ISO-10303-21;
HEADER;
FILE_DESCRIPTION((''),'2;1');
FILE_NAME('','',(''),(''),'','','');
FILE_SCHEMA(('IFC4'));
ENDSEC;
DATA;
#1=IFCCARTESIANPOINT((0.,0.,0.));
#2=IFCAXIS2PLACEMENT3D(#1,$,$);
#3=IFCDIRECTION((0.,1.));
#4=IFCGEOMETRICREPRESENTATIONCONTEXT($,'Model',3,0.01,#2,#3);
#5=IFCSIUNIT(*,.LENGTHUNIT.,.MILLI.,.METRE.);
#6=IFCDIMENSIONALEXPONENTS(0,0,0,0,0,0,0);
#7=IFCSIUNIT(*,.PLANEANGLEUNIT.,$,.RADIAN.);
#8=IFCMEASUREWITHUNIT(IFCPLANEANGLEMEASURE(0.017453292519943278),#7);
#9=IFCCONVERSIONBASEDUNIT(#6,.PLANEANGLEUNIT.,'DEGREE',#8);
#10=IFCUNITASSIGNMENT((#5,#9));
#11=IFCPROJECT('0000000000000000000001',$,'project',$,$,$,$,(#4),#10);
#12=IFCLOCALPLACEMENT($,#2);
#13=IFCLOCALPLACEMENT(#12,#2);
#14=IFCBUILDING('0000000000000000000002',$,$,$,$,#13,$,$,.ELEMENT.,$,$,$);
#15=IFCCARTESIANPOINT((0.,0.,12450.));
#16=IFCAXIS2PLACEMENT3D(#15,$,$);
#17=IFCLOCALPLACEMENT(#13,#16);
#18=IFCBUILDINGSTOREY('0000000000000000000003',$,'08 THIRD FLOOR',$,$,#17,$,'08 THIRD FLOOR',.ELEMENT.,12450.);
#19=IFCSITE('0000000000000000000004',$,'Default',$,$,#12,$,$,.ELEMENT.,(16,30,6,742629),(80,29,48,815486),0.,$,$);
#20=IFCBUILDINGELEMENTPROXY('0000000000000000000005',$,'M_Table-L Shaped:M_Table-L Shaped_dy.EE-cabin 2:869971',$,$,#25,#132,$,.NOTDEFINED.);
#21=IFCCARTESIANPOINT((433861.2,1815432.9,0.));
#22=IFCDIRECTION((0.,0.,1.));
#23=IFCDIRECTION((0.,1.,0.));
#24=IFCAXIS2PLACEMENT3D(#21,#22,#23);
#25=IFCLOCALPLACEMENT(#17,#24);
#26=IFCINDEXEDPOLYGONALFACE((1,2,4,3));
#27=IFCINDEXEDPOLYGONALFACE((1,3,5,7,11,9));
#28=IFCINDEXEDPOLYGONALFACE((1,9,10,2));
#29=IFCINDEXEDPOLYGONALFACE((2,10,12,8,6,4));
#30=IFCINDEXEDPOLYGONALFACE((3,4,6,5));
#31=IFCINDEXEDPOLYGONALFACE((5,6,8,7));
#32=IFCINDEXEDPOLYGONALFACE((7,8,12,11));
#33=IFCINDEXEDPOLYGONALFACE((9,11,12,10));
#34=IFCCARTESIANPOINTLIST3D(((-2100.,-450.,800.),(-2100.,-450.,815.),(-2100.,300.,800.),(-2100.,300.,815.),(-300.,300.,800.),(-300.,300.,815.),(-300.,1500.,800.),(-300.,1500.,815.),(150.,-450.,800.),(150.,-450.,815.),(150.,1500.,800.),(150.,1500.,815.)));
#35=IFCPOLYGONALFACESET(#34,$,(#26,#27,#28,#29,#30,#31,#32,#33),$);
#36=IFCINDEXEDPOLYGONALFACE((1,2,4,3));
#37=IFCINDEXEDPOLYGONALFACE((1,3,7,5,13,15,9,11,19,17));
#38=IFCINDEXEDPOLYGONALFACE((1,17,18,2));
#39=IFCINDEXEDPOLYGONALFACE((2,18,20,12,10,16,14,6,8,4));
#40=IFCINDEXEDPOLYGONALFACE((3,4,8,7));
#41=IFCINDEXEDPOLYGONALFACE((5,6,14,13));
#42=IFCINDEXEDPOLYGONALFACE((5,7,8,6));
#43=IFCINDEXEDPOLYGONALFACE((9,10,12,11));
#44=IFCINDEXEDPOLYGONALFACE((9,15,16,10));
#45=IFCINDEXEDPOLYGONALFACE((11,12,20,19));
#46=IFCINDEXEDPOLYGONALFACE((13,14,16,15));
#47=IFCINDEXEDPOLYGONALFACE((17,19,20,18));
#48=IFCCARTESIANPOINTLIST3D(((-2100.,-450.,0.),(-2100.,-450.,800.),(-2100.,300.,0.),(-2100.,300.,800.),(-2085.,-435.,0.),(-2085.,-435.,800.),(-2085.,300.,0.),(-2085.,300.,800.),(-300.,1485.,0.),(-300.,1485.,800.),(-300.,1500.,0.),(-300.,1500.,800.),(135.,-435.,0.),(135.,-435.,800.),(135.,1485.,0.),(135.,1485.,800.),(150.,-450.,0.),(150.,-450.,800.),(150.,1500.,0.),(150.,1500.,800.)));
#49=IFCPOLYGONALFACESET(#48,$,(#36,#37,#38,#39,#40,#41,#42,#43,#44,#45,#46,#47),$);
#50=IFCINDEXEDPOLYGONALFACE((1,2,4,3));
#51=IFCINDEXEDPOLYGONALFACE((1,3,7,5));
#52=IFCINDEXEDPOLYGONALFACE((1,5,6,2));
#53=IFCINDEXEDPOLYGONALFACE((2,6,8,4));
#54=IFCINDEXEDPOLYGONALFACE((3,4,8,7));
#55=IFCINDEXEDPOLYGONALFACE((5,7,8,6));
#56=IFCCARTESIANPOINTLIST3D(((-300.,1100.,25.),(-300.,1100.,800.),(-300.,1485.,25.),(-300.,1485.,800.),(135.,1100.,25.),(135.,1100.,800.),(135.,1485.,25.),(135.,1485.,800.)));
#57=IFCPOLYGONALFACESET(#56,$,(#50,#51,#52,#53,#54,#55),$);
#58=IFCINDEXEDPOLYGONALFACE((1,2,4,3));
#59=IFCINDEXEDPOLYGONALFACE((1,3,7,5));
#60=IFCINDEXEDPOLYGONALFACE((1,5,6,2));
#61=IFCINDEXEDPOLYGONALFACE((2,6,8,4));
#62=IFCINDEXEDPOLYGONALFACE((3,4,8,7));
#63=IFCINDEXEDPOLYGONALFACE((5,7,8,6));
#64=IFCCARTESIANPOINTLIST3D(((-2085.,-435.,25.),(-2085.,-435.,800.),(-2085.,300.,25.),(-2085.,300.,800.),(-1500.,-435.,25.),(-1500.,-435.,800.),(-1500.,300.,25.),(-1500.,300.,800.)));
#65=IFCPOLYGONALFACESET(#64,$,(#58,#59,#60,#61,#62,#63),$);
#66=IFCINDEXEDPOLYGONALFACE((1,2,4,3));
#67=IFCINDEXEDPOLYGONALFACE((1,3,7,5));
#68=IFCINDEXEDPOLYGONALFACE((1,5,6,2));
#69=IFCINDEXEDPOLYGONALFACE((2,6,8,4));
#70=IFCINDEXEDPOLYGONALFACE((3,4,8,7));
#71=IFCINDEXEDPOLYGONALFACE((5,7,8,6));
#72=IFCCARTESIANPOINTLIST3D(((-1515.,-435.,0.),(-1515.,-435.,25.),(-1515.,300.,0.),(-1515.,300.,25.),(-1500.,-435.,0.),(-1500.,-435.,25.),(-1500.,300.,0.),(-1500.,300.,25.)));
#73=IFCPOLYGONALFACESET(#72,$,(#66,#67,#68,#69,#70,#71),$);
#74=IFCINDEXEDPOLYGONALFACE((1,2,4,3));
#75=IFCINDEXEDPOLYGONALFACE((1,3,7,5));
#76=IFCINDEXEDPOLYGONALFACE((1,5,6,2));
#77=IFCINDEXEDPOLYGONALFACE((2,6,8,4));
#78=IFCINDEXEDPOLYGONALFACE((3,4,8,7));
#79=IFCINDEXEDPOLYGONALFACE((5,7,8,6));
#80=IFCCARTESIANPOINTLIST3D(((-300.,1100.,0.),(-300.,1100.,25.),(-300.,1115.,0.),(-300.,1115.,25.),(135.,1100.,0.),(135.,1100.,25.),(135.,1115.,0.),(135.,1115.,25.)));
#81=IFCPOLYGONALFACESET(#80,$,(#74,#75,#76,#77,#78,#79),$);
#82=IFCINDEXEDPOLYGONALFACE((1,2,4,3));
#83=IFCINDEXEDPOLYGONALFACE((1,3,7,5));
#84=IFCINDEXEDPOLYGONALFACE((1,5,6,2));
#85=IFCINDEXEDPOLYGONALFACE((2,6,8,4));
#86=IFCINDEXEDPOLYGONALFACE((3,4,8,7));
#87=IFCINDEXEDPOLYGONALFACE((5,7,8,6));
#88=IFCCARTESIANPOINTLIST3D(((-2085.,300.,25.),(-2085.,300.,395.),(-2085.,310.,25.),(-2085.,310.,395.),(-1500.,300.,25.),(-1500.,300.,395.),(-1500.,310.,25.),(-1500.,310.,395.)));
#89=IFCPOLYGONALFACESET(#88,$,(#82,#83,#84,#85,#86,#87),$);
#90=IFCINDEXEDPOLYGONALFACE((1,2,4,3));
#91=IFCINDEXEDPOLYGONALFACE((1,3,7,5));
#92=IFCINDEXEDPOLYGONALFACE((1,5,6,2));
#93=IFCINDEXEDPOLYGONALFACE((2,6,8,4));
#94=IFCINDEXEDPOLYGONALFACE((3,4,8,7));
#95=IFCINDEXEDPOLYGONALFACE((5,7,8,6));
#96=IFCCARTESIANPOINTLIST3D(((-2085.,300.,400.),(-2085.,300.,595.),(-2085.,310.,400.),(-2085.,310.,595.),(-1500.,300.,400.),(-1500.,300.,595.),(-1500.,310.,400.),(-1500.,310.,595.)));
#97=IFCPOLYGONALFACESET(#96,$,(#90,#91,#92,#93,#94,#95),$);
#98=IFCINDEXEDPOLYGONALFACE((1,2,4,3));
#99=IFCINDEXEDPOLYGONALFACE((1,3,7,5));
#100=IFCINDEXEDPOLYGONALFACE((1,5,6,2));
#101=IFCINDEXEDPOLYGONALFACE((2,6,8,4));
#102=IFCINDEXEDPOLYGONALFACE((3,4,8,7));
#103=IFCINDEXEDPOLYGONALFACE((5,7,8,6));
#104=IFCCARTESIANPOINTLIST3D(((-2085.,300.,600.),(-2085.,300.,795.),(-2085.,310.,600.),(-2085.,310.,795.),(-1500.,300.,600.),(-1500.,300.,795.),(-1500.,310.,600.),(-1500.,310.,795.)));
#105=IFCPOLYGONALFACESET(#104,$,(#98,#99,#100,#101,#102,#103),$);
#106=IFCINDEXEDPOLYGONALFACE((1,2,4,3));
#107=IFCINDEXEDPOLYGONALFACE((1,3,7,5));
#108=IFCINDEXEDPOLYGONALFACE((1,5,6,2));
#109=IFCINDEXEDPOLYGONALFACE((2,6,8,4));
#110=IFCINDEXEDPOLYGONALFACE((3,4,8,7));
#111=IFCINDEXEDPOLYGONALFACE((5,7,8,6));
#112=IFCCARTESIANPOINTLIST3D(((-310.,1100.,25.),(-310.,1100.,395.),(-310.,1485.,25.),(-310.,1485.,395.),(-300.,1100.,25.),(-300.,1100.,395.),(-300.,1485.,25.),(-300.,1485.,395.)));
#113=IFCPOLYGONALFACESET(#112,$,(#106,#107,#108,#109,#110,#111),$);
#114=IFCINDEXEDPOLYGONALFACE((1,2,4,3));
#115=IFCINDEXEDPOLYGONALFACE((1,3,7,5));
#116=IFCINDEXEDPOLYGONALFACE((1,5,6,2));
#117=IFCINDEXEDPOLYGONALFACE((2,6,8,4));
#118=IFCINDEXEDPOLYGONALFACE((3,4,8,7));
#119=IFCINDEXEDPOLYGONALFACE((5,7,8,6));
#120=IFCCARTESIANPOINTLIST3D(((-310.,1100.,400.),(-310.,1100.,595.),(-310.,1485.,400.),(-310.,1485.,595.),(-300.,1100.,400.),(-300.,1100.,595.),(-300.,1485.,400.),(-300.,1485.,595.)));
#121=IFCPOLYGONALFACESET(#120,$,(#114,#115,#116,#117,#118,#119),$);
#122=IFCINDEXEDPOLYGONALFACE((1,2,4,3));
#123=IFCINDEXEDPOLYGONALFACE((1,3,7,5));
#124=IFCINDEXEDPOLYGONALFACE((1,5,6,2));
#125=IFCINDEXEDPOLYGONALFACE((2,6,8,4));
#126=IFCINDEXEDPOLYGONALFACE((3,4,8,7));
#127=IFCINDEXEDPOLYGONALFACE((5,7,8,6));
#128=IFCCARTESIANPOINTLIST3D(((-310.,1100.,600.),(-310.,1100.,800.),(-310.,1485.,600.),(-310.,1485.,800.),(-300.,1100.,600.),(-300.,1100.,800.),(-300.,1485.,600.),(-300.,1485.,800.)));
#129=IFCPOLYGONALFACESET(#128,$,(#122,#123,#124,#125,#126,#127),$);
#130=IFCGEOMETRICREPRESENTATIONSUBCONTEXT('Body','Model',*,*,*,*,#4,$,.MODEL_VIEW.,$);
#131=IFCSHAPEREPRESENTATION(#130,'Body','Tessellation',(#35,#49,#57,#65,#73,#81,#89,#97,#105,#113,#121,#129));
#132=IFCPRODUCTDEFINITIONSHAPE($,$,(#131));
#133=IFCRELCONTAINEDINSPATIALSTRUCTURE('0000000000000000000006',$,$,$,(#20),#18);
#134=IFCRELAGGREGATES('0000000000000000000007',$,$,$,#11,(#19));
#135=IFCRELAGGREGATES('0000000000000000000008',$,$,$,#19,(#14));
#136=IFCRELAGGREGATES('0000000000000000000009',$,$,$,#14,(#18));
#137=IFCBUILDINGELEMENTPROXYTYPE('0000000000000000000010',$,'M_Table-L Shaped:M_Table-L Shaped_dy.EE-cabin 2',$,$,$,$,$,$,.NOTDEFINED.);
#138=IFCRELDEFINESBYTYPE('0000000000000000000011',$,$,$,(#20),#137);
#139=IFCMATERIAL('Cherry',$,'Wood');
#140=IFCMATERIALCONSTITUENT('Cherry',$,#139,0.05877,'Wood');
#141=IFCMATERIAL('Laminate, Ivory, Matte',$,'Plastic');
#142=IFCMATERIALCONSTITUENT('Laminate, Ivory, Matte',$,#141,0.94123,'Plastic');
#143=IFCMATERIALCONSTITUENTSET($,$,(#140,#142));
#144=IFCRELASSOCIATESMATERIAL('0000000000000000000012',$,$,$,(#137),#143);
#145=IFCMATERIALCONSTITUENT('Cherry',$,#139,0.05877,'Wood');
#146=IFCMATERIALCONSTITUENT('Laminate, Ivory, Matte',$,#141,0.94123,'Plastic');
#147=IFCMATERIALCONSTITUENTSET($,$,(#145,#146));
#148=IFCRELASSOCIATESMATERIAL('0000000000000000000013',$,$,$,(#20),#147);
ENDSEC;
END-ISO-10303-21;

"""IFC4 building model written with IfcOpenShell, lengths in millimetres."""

from ifc_helpers import new_model, entity, si_unit, converted_unit, direction, frame, origin, place, context, subcontext, project, spatial, indexed_curve, outline, extrude, source, transform, mapped, material, constituent, constituent_set, type_object, type_shapes, element, save


model = new_model("IFC4")

# Units and contexts
model_context = context("Model", 3, precision=0.01, world=origin(), true_north=direction((0.0, 1.0)))
body_context = subcontext(model_context, "Body", "Model", "MODEL_VIEW")
ifc_project = project(units=[si_unit("LENGTHUNIT", "METRE", prefix="MILLI"), converted_unit("PLANEANGLEUNIT", "DEGREE", entity("IfcPlaneAngleMeasure", 0.017453292519943278), si_unit("PLANEANGLEUNIT", "RADIAN"), dimensions=[0, 0, 0, 0, 0, 0, 0])], contexts=[model_context])

# Site, building, storey
site_placement = place(None, origin())
site = spatial("IfcSite", under=ifc_project, at=site_placement, Name="Default", CompositionType="ELEMENT", RefLatitude=(16, 30, 6, 742629), RefLongitude=(80, 29, 48, 815486), RefElevation=0.0)
building_placement = place(site_placement, origin())
building = spatial("IfcBuilding", under=site, at=building_placement, CompositionType="ELEMENT")
storey_placement = place(building_placement, frame((0.0, 0.0, 12450.0)))
storey = spatial("IfcBuildingStorey", under=building, at=storey_placement, Name="08 THIRD FLOOR", LongName="08 THIRD FLOOR", CompositionType="ELEMENT", Elevation=12450.0)

# Building element proxy
ifc_material_1 = material(Name="Cherry", Category="Wood")
ifc_constituent_1 = constituent(ifc_material_1, Name="Cherry", Category="Wood", fraction=0.05877)
ifc_material_2 = material(Name="Laminate, Ivory, Matte", Category="Plastic")
ifc_constituent_2 = constituent(ifc_material_2, Name="Laminate, Ivory, Matte", Category="Plastic", fraction=0.94123)
ifc_constituent_set_1 = constituent_set(constituents=[ifc_constituent_1, ifc_constituent_2])
ifc_constituent_3 = constituent(ifc_material_1, Name="Cherry", Category="Wood", fraction=0.05877)
ifc_constituent_4 = constituent(ifc_material_2, Name="Laminate, Ivory, Matte", Category="Plastic", fraction=0.94123)
ifc_constituent_set_2 = constituent_set(constituents=[ifc_constituent_3, ifc_constituent_4])
building_element_proxy_type_1 = type_object("IfcBuildingElementProxyType", Name="M_Table-L Shaped:M_Table-L Shaped_dy.EE-cabin 2", PredefinedType="NOTDEFINED", material=ifc_constituent_set_2)
shared_shape_1 = source(origin(), body_context, "Body", "SweptSolid", [
    extrude(outline(indexed_curve([(-1050.0, -450.0), (-1050.0, -900.0), (900.0, -900.0), (900.0, 1350.0), (150.0, 1350.0), (150.0, -450.0), (-1050.0, -450.0)], self_intersect=False)), frame((-750.0, 450.0, 800.0), z_axis=(0.0, 0.0, -1.0), x_axis=(0.0, -1.0, 0.0)), (0.0, 0.0, -1.0), 15.0),
    extrude(outline(indexed_curve([(-1020.0, 540.0), (-1005.0, 540.0), (-1005.0, 975.0), (915.0, 975.0), (915.0, -1245.0), (180.0, -1245.0), (180.0, -1260.0), (930.0, -1260.0), (930.0, 990.0), (-1020.0, 990.0), (-1020.0, 540.0)], self_intersect=False)), frame((-840.0, 480.0, 0.0), z_axis=(0.0, 0.0, 1.0), x_axis=(0.0, -1.0, 0.0)), (0.0, 0.0, 1.0), 800.0),
    extrude(outline(indexed_curve([(-217.5, -192.5), (217.5, -192.5), (217.5, 192.5), (-217.5, 192.5), (-217.5, -192.5)], self_intersect=False)), frame((-82.5, 1292.5, 25.0), z_axis=(0.0, 0.0, 1.0), x_axis=(-1.0, 0.0, 0.0)), (0.0, 0.0, 1.0), 775.0),
    extrude(outline(indexed_curve([(-367.5, -292.5), (367.5, -292.5), (367.5, 292.5), (-367.5, 292.5), (-367.5, -292.5)], self_intersect=False)), frame((-1792.5, -67.5, 25.0), z_axis=(0.0, 0.0, 1.0), x_axis=(0.0, -1.0, 0.0)), (0.0, 0.0, 1.0), 775.0),
    extrude(outline(indexed_curve([(-7.5, -367.5), (7.5, -367.5), (7.5, 367.5), (-7.5, 367.5), (-7.5, -367.5)], self_intersect=False)), frame((-1507.5, -67.5, 0.0), z_axis=(0.0, 0.0, 1.0), x_axis=(-1.0, 0.0, 0.0)), (0.0, 0.0, 1.0), 25.0),
    extrude(outline(indexed_curve([(-7.5, -217.5), (7.5, -217.5), (7.5, 217.5), (-7.5, 217.5), (-7.5, -217.5)], self_intersect=False)), frame((-82.5, 1107.5, 0.0), z_axis=(0.0, 0.0, 1.0), x_axis=(0.0, 1.0, 0.0)), (0.0, 0.0, 1.0), 25.0),
    extrude(outline(indexed_curve([(-5.0, -292.5), (5.0, -292.5), (5.0, 292.5), (-5.0, 292.5), (-5.0, -292.5)], self_intersect=False)), frame((-1792.5, 305.0, 25.0), z_axis=(0.0, 0.0, 1.0), x_axis=(0.0, 1.0, 0.0)), (0.0, 0.0, 1.0), 370.0),
    extrude(outline(indexed_curve([(-5.0, -292.5), (5.0, -292.5), (5.0, 292.5), (-5.0, 292.5), (-5.0, -292.5)], self_intersect=False)), frame((-1792.5, 305.0, 400.0), z_axis=(0.0, 0.0, 1.0), x_axis=(0.0, 1.0, 0.0)), (0.0, 0.0, 1.0), 195.0),
    extrude(outline(indexed_curve([(-5.0, -292.5), (5.0, -292.5), (5.0, 292.5), (-5.0, 292.5), (-5.0, -292.5)], self_intersect=False)), frame((-1792.5, 305.0, 600.0), z_axis=(0.0, 0.0, 1.0), x_axis=(0.0, 1.0, 0.0)), (0.0, 0.0, 1.0), 195.0),
    extrude(outline(indexed_curve([(-192.5, -5.0), (192.5, -5.0), (192.5, 5.0), (-192.5, 5.0), (-192.5, -5.0)], self_intersect=False)), frame((-305.0, 1292.5, 25.0), z_axis=(0.0, 0.0, 1.0), x_axis=(0.0, -1.0, 0.0)), (0.0, 0.0, 1.0), 370.0),
    extrude(outline(indexed_curve([(-192.5, -5.0), (192.5, -5.0), (192.5, 5.0), (-192.5, 5.0), (-192.5, -5.0)], self_intersect=False)), frame((-305.0, 1292.5, 400.0), z_axis=(0.0, 0.0, 1.0), x_axis=(0.0, -1.0, 0.0)), (0.0, 0.0, 1.0), 195.0),
    extrude(outline(indexed_curve([(-192.5, -5.0), (192.5, -5.0), (192.5, 5.0), (-192.5, 5.0), (-192.5, -5.0)], self_intersect=False)), frame((-305.0, 1292.5, 600.0), z_axis=(0.0, 0.0, 1.0), x_axis=(0.0, -1.0, 0.0)), (0.0, 0.0, 1.0), 200.0),
])
type_shapes(building_element_proxy_type_1, [shared_shape_1])
proxy_1_placement = place(storey_placement, frame((433861.2, 1815432.9, 0.0), z_axis=(0.0, 0.0, 1.0), x_axis=(0.0, 1.0, 0.0)))
element("IfcBuildingElementProxy", 1, at=proxy_1_placement, inside=storey, type_object=building_element_proxy_type_1, material=ifc_constituent_set_1, Name="M_Table-L Shaped:M_Table-L Shaped_dy.EE-cabin 2:869971", PredefinedType="NOTDEFINED", context=body_context, shape_type="MappedRepresentation", body=[
    mapped(shared_shape_1, transform((0.0, 0.0, 0.0), scale=1.0)),
])

save(model, "model.ifc")
